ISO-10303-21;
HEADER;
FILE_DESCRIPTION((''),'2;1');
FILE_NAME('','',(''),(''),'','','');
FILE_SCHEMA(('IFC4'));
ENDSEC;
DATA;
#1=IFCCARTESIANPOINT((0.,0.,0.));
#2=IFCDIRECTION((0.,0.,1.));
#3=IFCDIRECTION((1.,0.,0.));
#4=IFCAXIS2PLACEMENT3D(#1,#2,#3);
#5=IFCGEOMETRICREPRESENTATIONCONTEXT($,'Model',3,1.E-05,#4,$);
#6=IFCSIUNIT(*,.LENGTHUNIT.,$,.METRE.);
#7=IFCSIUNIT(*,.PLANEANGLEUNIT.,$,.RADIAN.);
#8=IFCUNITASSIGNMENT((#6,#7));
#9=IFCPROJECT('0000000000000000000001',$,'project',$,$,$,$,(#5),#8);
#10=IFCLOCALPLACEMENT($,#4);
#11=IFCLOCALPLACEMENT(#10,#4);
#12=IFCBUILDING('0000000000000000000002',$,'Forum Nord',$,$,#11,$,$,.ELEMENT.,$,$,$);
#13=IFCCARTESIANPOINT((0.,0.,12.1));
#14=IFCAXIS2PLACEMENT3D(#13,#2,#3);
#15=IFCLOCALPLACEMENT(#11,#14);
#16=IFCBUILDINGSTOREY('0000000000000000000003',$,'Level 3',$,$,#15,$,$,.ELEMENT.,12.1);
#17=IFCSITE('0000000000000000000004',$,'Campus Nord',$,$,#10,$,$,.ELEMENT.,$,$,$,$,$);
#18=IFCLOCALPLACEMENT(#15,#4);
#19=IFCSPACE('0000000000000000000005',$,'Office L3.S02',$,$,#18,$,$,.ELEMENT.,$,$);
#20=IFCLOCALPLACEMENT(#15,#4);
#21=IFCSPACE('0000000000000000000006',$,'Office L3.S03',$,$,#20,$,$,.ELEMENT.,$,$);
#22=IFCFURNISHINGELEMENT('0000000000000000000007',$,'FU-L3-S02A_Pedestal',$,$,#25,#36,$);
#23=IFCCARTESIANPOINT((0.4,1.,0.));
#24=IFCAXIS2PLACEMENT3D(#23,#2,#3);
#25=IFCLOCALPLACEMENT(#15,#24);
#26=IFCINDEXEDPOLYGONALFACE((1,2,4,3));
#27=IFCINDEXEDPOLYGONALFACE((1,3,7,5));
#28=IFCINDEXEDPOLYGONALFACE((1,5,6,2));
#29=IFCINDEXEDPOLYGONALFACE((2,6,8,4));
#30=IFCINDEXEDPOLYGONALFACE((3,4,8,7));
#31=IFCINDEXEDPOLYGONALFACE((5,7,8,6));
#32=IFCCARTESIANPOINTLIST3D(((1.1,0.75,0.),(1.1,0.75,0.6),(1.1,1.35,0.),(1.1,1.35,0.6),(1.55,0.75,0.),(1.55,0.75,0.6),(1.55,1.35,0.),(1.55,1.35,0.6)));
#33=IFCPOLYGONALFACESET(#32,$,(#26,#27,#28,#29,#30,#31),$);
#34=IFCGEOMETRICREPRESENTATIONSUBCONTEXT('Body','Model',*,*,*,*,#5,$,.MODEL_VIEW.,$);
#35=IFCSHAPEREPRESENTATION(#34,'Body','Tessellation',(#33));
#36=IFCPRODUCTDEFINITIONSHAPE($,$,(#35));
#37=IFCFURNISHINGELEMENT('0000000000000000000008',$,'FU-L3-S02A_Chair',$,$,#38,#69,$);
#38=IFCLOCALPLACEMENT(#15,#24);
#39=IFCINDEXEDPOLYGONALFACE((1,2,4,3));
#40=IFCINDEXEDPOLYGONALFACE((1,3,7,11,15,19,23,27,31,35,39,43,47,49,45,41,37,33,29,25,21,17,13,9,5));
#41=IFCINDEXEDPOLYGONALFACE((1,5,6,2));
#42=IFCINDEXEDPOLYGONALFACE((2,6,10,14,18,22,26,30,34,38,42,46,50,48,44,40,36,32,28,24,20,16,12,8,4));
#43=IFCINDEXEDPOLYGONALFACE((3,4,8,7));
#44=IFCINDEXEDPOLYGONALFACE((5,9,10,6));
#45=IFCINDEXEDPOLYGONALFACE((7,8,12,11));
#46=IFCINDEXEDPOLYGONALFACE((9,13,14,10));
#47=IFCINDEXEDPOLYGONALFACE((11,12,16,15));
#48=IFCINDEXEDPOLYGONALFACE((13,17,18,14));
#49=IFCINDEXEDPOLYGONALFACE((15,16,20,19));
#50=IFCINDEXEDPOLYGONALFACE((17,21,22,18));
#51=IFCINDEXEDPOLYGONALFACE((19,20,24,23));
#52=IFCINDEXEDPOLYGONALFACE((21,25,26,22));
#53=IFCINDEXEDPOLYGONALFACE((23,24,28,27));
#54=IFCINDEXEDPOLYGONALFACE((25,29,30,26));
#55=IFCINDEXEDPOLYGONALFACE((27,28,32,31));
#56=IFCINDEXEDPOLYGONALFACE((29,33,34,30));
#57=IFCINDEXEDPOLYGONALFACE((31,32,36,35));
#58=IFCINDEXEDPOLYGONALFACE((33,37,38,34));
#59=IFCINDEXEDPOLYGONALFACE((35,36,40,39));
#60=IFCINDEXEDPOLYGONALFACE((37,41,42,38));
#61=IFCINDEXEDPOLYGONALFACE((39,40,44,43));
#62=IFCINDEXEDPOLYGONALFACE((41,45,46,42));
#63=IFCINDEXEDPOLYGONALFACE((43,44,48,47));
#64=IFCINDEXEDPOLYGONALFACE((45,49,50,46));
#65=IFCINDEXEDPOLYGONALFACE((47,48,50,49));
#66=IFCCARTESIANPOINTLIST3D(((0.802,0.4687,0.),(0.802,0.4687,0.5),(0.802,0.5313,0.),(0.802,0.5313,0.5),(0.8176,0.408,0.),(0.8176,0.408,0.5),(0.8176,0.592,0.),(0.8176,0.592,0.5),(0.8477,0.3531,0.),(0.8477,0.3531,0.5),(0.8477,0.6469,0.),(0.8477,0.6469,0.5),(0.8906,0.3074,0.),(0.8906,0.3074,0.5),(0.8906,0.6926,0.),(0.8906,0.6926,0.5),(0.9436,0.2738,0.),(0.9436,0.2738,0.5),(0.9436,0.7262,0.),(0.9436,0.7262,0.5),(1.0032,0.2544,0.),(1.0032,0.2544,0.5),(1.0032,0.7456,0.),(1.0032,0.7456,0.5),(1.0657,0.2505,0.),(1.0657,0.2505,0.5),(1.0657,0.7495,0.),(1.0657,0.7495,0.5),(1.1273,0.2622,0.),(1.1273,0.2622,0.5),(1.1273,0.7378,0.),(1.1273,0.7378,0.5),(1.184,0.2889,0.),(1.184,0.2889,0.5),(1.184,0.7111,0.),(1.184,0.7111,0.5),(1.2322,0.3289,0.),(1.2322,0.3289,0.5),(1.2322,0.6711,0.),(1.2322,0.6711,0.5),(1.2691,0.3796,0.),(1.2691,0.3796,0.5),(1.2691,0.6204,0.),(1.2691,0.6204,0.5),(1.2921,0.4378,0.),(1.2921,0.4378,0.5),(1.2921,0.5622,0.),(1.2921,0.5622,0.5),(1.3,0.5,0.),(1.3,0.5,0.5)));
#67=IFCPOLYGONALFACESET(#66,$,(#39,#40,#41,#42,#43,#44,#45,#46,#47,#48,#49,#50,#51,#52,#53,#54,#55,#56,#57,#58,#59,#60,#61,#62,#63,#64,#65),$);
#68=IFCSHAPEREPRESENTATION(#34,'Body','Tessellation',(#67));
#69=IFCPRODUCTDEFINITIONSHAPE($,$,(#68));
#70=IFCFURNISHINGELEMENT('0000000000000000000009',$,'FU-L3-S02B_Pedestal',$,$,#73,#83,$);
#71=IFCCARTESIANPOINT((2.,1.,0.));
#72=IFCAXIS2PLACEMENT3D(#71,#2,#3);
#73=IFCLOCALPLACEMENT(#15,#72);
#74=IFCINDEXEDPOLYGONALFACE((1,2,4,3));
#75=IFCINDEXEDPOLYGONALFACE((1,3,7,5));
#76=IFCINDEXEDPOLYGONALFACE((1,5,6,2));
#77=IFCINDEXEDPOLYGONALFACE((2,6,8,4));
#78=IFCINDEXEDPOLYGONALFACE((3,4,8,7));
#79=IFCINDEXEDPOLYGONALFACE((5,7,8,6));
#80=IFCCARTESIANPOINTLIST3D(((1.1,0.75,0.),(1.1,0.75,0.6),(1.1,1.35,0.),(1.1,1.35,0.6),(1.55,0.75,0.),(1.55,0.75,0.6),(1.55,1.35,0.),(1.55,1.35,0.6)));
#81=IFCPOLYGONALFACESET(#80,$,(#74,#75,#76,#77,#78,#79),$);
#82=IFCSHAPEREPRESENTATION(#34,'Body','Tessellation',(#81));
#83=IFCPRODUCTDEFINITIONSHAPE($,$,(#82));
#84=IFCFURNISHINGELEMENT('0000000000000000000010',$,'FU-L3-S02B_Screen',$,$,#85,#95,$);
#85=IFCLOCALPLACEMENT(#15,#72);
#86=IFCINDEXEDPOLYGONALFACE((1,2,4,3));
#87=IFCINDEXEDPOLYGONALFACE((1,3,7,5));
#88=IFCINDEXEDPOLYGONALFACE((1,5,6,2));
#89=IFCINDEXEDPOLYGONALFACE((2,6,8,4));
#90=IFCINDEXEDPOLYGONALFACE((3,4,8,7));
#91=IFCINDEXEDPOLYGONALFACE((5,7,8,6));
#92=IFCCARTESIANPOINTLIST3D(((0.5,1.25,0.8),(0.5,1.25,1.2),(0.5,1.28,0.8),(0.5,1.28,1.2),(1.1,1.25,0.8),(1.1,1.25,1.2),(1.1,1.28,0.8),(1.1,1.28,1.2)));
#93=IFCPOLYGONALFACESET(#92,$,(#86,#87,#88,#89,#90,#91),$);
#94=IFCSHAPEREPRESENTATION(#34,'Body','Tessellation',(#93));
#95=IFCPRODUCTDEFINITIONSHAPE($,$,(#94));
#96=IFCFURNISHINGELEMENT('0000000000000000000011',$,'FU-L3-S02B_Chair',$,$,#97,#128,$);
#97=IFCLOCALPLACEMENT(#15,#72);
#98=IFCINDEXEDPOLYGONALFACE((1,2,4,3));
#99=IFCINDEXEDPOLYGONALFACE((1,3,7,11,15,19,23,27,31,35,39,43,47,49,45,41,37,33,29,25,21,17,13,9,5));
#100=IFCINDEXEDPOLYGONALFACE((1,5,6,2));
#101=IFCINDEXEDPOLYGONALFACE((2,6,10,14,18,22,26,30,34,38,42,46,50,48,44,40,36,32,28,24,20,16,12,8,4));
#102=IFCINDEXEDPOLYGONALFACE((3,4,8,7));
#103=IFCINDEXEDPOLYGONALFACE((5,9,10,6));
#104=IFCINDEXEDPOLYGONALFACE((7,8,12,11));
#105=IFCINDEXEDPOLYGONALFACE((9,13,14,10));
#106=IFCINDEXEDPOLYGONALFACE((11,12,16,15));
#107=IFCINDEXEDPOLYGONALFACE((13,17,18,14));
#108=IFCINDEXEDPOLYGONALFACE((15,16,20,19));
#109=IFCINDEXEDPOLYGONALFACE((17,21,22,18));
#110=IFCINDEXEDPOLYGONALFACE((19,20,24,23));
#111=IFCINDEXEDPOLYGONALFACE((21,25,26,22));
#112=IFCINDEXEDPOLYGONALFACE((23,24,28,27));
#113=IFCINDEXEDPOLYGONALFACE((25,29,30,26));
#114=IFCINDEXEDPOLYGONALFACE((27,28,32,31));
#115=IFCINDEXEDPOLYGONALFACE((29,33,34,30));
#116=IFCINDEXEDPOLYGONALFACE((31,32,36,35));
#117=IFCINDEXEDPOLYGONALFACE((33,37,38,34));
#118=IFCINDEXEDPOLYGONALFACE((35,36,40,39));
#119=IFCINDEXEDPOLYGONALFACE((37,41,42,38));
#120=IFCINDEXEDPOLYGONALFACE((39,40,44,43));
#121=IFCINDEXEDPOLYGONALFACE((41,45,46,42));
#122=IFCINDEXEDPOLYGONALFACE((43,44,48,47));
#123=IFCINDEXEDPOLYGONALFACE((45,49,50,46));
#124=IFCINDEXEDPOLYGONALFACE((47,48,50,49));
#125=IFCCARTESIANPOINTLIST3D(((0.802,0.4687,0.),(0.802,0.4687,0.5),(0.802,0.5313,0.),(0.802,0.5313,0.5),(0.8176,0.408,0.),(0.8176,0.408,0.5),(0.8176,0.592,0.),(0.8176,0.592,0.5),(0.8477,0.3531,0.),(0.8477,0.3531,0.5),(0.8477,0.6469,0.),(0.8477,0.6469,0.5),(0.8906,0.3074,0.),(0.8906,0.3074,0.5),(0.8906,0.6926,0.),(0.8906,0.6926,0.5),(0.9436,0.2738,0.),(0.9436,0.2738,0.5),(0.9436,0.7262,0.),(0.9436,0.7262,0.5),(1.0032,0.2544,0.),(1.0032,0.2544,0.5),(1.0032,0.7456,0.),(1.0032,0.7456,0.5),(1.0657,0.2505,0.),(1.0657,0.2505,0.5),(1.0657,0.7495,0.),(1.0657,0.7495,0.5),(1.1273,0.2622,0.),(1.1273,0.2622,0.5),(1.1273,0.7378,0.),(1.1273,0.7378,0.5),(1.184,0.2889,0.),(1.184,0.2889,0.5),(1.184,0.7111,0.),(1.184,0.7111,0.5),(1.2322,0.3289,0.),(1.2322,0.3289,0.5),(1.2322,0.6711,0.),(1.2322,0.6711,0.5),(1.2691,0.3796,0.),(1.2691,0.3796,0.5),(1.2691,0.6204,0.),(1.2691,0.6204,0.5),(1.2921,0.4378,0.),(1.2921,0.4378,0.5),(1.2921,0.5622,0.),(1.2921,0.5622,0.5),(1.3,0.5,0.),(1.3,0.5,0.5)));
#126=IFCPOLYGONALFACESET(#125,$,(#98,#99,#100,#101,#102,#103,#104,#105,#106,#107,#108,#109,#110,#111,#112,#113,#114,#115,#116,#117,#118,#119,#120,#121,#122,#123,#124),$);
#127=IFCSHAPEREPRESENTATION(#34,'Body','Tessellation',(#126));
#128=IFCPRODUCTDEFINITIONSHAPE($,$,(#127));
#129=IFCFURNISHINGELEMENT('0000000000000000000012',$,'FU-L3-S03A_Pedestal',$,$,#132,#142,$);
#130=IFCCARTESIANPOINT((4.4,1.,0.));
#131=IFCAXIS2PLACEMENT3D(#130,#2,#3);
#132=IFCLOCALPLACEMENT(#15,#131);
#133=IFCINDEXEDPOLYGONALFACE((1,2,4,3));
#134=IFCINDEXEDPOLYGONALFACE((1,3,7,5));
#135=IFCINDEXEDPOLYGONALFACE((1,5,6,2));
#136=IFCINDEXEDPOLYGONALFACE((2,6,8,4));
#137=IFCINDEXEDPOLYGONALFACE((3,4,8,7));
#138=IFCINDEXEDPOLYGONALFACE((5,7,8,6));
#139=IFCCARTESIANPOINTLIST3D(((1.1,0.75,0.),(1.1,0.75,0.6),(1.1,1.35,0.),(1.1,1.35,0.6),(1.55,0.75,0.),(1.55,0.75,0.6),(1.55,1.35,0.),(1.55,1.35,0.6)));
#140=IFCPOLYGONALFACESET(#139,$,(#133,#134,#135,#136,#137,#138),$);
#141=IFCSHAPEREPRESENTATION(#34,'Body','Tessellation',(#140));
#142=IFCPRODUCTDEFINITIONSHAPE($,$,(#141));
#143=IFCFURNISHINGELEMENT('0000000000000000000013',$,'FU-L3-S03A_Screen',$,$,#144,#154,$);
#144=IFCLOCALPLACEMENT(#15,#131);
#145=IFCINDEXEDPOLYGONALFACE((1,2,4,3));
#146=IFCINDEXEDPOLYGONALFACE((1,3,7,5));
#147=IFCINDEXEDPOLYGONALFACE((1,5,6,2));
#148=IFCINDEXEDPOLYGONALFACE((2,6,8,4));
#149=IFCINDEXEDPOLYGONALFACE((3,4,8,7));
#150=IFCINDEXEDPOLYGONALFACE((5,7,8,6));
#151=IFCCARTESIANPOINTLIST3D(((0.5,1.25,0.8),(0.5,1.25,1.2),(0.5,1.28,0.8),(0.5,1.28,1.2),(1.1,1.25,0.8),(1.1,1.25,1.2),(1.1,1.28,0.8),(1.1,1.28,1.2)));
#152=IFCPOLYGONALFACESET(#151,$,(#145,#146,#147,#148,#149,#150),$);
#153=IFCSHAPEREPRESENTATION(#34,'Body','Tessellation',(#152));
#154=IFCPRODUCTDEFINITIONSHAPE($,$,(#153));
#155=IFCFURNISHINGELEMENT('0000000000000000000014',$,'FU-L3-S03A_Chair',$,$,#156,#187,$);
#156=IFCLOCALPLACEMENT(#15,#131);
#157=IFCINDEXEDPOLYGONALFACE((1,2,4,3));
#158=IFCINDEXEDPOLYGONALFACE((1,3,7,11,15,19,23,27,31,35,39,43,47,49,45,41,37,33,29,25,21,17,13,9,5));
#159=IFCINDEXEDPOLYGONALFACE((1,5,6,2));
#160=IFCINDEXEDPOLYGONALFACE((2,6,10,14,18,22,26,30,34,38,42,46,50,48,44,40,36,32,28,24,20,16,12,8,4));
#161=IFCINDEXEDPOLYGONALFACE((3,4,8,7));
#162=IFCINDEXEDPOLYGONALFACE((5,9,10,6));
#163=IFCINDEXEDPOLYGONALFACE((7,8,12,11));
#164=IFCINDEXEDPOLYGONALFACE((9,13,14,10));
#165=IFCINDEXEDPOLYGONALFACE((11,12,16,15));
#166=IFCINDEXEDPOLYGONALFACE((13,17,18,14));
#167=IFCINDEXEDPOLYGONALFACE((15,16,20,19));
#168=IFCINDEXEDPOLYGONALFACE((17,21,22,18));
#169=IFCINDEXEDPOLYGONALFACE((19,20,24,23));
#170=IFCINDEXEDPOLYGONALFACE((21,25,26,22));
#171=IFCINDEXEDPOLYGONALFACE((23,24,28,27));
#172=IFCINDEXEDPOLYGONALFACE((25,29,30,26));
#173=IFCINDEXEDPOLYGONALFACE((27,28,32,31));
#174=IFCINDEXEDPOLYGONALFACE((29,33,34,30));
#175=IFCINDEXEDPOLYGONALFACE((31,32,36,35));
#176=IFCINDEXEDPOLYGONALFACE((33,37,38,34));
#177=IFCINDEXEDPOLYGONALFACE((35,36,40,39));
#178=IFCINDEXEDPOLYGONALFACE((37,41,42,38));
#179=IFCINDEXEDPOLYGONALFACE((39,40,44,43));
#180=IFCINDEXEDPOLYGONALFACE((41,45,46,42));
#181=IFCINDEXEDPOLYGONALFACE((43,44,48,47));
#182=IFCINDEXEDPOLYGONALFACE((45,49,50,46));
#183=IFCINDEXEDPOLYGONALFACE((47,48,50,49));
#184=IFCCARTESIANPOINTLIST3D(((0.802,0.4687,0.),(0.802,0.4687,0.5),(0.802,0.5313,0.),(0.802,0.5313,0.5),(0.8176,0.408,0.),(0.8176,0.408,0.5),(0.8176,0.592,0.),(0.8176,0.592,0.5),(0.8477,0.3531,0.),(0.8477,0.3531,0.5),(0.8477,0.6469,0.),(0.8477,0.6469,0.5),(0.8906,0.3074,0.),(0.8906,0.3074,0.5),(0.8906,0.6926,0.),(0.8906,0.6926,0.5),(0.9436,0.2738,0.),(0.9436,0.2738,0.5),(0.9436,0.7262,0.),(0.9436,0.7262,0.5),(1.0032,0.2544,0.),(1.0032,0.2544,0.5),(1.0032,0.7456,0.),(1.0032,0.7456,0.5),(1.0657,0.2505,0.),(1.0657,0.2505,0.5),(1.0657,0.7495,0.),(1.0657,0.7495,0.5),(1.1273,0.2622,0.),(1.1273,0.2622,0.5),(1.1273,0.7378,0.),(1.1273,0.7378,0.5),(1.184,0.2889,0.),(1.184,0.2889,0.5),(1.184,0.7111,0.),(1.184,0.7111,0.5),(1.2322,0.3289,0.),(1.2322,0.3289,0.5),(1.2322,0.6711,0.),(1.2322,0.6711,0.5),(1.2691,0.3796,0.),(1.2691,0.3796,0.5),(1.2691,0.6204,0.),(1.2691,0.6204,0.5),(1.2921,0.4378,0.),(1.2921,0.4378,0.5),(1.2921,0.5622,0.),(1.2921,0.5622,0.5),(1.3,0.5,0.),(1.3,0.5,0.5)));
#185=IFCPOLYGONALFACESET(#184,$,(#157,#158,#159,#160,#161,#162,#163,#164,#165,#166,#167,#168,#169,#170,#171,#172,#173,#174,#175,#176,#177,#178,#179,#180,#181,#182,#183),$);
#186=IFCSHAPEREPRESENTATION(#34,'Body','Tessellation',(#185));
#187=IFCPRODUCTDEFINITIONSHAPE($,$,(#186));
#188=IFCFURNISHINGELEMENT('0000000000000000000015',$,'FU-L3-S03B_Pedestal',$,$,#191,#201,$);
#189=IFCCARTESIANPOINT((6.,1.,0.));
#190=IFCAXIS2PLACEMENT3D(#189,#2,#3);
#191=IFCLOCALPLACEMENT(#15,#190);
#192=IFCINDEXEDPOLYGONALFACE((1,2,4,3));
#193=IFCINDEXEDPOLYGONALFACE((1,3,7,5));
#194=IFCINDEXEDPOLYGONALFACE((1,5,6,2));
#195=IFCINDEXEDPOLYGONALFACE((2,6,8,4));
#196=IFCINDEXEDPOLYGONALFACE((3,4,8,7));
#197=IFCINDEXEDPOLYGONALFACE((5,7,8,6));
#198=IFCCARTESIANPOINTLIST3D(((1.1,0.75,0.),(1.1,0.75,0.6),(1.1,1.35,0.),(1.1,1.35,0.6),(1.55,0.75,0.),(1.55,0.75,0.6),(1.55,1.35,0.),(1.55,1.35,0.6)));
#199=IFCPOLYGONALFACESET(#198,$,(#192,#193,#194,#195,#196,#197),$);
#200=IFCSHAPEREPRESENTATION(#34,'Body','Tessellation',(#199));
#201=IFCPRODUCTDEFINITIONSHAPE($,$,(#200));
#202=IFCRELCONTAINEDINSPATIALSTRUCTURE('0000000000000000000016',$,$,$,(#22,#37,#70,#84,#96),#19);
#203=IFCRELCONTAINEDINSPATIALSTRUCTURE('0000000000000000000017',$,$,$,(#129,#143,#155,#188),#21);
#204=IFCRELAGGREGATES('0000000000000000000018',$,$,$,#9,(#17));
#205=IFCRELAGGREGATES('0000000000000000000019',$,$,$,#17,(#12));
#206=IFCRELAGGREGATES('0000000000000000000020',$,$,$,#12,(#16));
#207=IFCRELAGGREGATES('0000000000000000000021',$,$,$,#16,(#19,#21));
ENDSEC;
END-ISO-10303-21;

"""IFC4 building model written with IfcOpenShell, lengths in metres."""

from ifc_helpers import new_model, si_unit, frame, frame_2d, origin_with_axes, place, context, subcontext, project, spatial, rectangle, circle, extrude, element, save


model = new_model("IFC4")

# Units and contexts
model_context = context("Model", 3, precision=1e-05, world=origin_with_axes())
body_context = subcontext(model_context, "Body", "Model", "MODEL_VIEW")
ifc_project = project(units=[si_unit("LENGTHUNIT", "METRE"), si_unit("PLANEANGLEUNIT", "RADIAN")], contexts=[model_context])

# Site, building, storey
site_placement = place(None, origin_with_axes())
site = spatial("IfcSite", under=ifc_project, at=site_placement, Name="Campus Nord", CompositionType="ELEMENT")
building_placement = place(site_placement, origin_with_axes())
building = spatial("IfcBuilding", under=site, at=building_placement, Name="Forum Nord", CompositionType="ELEMENT")
storey_placement = place(building_placement, frame((0.0, 0.0, 12.1), z_axis=(0.0, 0.0, 1.0), x_axis=(1.0, 0.0, 0.0)))
storey = spatial("IfcBuildingStorey", under=building, at=storey_placement, Name="Level 3", CompositionType="ELEMENT", Elevation=12.1)

# Shared definitions
space_1_placement = place(storey_placement, origin_with_axes())
space_1 = spatial("IfcSpace", under=storey, at=space_1_placement, Name="Office L3.S02", CompositionType="ELEMENT")

# Furnishing elements
furnishing_1_placement = place(storey_placement, frame((0.4, 1.0, 0.0), z_axis=(0.0, 0.0, 1.0), x_axis=(1.0, 0.0, 0.0)))
element("IfcFurnishingElement", 1, at=furnishing_1_placement, inside=space_1, Name="FU-L3-S02A_Pedestal", context=body_context, shape_type="SweptSolid", body=[
    extrude(rectangle(XDim=0.45, YDim=0.6, at=frame_2d((1.325, 1.05), x_axis=(1.0, 0.0))), origin_with_axes(), (0.0, 0.0, 1.0), 0.6),
])
furnishing_2_placement = place(storey_placement, frame((0.4, 1.0, 0.0), z_axis=(0.0, 0.0, 1.0), x_axis=(1.0, 0.0, 0.0)))
element("IfcFurnishingElement", 2, at=furnishing_2_placement, inside=space_1, Name="FU-L3-S02A_Chair", context=body_context, shape_type="SweptSolid", body=[
    extrude(circle(Radius=0.25, at=frame_2d((1.05, 0.5), x_axis=(1.0, 0.0))), origin_with_axes(), (0.0, 0.0, 1.0), 0.5),
])
furnishing_3_placement = place(storey_placement, frame((2.0, 1.0, 0.0), z_axis=(0.0, 0.0, 1.0), x_axis=(1.0, 0.0, 0.0)))
element("IfcFurnishingElement", 3, at=furnishing_3_placement, inside=space_1, Name="FU-L3-S02B_Pedestal", context=body_context, shape_type="SweptSolid", body=[
    extrude(rectangle(XDim=0.45, YDim=0.6, at=frame_2d((1.325, 1.05), x_axis=(1.0, 0.0))), origin_with_axes(), (0.0, 0.0, 1.0), 0.6),
])
furnishing_4_placement = place(storey_placement, frame((2.0, 1.0, 0.0), z_axis=(0.0, 0.0, 1.0), x_axis=(1.0, 0.0, 0.0)))
element("IfcFurnishingElement", 4, at=furnishing_4_placement, inside=space_1, Name="FU-L3-S02B_Screen", context=body_context, shape_type="SweptSolid", body=[
    extrude(rectangle(XDim=0.6, YDim=0.03, at=frame_2d((0.8, 1.265), x_axis=(1.0, 0.0))), frame((0.0, 0.0, 0.8), z_axis=(0.0, 0.0, 1.0), x_axis=(1.0, 0.0, 0.0)), (0.0, 0.0, 1.0), 0.4),
])
furnishing_5_placement = place(storey_placement, frame((2.0, 1.0, 0.0), z_axis=(0.0, 0.0, 1.0), x_axis=(1.0, 0.0, 0.0)))
element("IfcFurnishingElement", 5, at=furnishing_5_placement, inside=space_1, Name="FU-L3-S02B_Chair", context=body_context, shape_type="SweptSolid", body=[
    extrude(circle(Radius=0.25, at=frame_2d((1.05, 0.5), x_axis=(1.0, 0.0))), origin_with_axes(), (0.0, 0.0, 1.0), 0.5),
])

# Shared definitions
space_2_placement = place(storey_placement, origin_with_axes())
space_2 = spatial("IfcSpace", under=storey, at=space_2_placement, Name="Office L3.S03", CompositionType="ELEMENT")

# Furnishing elements
furnishing_6_placement = place(storey_placement, frame((4.4, 1.0, 0.0), z_axis=(0.0, 0.0, 1.0), x_axis=(1.0, 0.0, 0.0)))
element("IfcFurnishingElement", 6, at=furnishing_6_placement, inside=space_2, Name="FU-L3-S03A_Pedestal", context=body_context, shape_type="SweptSolid", body=[
    extrude(rectangle(XDim=0.45, YDim=0.6, at=frame_2d((1.325, 1.05), x_axis=(1.0, 0.0))), origin_with_axes(), (0.0, 0.0, 1.0), 0.6),
])
furnishing_7_placement = place(storey_placement, frame((4.4, 1.0, 0.0), z_axis=(0.0, 0.0, 1.0), x_axis=(1.0, 0.0, 0.0)))
element("IfcFurnishingElement", 7, at=furnishing_7_placement, inside=space_2, Name="FU-L3-S03A_Screen", context=body_context, shape_type="SweptSolid", body=[
    extrude(rectangle(XDim=0.6, YDim=0.03, at=frame_2d((0.8, 1.265), x_axis=(1.0, 0.0))), frame((0.0, 0.0, 0.8), z_axis=(0.0, 0.0, 1.0), x_axis=(1.0, 0.0, 0.0)), (0.0, 0.0, 1.0), 0.4),
])
furnishing_8_placement = place(storey_placement, frame((4.4, 1.0, 0.0), z_axis=(0.0, 0.0, 1.0), x_axis=(1.0, 0.0, 0.0)))
element("IfcFurnishingElement", 8, at=furnishing_8_placement, inside=space_2, Name="FU-L3-S03A_Chair", context=body_context, shape_type="SweptSolid", body=[
    extrude(circle(Radius=0.25, at=frame_2d((1.05, 0.5), x_axis=(1.0, 0.0))), origin_with_axes(), (0.0, 0.0, 1.0), 0.5),
])
furnishing_9_placement = place(storey_placement, frame((6.0, 1.0, 0.0), z_axis=(0.0, 0.0, 1.0), x_axis=(1.0, 0.0, 0.0)))
element("IfcFurnishingElement", 9, at=furnishing_9_placement, inside=space_2, Name="FU-L3-S03B_Pedestal", context=body_context, shape_type="SweptSolid", body=[
    extrude(rectangle(XDim=0.45, YDim=0.6, at=frame_2d((1.325, 1.05), x_axis=(1.0, 0.0))), origin_with_axes(), (0.0, 0.0, 1.0), 0.6),
])

save(model, "model.ifc")
